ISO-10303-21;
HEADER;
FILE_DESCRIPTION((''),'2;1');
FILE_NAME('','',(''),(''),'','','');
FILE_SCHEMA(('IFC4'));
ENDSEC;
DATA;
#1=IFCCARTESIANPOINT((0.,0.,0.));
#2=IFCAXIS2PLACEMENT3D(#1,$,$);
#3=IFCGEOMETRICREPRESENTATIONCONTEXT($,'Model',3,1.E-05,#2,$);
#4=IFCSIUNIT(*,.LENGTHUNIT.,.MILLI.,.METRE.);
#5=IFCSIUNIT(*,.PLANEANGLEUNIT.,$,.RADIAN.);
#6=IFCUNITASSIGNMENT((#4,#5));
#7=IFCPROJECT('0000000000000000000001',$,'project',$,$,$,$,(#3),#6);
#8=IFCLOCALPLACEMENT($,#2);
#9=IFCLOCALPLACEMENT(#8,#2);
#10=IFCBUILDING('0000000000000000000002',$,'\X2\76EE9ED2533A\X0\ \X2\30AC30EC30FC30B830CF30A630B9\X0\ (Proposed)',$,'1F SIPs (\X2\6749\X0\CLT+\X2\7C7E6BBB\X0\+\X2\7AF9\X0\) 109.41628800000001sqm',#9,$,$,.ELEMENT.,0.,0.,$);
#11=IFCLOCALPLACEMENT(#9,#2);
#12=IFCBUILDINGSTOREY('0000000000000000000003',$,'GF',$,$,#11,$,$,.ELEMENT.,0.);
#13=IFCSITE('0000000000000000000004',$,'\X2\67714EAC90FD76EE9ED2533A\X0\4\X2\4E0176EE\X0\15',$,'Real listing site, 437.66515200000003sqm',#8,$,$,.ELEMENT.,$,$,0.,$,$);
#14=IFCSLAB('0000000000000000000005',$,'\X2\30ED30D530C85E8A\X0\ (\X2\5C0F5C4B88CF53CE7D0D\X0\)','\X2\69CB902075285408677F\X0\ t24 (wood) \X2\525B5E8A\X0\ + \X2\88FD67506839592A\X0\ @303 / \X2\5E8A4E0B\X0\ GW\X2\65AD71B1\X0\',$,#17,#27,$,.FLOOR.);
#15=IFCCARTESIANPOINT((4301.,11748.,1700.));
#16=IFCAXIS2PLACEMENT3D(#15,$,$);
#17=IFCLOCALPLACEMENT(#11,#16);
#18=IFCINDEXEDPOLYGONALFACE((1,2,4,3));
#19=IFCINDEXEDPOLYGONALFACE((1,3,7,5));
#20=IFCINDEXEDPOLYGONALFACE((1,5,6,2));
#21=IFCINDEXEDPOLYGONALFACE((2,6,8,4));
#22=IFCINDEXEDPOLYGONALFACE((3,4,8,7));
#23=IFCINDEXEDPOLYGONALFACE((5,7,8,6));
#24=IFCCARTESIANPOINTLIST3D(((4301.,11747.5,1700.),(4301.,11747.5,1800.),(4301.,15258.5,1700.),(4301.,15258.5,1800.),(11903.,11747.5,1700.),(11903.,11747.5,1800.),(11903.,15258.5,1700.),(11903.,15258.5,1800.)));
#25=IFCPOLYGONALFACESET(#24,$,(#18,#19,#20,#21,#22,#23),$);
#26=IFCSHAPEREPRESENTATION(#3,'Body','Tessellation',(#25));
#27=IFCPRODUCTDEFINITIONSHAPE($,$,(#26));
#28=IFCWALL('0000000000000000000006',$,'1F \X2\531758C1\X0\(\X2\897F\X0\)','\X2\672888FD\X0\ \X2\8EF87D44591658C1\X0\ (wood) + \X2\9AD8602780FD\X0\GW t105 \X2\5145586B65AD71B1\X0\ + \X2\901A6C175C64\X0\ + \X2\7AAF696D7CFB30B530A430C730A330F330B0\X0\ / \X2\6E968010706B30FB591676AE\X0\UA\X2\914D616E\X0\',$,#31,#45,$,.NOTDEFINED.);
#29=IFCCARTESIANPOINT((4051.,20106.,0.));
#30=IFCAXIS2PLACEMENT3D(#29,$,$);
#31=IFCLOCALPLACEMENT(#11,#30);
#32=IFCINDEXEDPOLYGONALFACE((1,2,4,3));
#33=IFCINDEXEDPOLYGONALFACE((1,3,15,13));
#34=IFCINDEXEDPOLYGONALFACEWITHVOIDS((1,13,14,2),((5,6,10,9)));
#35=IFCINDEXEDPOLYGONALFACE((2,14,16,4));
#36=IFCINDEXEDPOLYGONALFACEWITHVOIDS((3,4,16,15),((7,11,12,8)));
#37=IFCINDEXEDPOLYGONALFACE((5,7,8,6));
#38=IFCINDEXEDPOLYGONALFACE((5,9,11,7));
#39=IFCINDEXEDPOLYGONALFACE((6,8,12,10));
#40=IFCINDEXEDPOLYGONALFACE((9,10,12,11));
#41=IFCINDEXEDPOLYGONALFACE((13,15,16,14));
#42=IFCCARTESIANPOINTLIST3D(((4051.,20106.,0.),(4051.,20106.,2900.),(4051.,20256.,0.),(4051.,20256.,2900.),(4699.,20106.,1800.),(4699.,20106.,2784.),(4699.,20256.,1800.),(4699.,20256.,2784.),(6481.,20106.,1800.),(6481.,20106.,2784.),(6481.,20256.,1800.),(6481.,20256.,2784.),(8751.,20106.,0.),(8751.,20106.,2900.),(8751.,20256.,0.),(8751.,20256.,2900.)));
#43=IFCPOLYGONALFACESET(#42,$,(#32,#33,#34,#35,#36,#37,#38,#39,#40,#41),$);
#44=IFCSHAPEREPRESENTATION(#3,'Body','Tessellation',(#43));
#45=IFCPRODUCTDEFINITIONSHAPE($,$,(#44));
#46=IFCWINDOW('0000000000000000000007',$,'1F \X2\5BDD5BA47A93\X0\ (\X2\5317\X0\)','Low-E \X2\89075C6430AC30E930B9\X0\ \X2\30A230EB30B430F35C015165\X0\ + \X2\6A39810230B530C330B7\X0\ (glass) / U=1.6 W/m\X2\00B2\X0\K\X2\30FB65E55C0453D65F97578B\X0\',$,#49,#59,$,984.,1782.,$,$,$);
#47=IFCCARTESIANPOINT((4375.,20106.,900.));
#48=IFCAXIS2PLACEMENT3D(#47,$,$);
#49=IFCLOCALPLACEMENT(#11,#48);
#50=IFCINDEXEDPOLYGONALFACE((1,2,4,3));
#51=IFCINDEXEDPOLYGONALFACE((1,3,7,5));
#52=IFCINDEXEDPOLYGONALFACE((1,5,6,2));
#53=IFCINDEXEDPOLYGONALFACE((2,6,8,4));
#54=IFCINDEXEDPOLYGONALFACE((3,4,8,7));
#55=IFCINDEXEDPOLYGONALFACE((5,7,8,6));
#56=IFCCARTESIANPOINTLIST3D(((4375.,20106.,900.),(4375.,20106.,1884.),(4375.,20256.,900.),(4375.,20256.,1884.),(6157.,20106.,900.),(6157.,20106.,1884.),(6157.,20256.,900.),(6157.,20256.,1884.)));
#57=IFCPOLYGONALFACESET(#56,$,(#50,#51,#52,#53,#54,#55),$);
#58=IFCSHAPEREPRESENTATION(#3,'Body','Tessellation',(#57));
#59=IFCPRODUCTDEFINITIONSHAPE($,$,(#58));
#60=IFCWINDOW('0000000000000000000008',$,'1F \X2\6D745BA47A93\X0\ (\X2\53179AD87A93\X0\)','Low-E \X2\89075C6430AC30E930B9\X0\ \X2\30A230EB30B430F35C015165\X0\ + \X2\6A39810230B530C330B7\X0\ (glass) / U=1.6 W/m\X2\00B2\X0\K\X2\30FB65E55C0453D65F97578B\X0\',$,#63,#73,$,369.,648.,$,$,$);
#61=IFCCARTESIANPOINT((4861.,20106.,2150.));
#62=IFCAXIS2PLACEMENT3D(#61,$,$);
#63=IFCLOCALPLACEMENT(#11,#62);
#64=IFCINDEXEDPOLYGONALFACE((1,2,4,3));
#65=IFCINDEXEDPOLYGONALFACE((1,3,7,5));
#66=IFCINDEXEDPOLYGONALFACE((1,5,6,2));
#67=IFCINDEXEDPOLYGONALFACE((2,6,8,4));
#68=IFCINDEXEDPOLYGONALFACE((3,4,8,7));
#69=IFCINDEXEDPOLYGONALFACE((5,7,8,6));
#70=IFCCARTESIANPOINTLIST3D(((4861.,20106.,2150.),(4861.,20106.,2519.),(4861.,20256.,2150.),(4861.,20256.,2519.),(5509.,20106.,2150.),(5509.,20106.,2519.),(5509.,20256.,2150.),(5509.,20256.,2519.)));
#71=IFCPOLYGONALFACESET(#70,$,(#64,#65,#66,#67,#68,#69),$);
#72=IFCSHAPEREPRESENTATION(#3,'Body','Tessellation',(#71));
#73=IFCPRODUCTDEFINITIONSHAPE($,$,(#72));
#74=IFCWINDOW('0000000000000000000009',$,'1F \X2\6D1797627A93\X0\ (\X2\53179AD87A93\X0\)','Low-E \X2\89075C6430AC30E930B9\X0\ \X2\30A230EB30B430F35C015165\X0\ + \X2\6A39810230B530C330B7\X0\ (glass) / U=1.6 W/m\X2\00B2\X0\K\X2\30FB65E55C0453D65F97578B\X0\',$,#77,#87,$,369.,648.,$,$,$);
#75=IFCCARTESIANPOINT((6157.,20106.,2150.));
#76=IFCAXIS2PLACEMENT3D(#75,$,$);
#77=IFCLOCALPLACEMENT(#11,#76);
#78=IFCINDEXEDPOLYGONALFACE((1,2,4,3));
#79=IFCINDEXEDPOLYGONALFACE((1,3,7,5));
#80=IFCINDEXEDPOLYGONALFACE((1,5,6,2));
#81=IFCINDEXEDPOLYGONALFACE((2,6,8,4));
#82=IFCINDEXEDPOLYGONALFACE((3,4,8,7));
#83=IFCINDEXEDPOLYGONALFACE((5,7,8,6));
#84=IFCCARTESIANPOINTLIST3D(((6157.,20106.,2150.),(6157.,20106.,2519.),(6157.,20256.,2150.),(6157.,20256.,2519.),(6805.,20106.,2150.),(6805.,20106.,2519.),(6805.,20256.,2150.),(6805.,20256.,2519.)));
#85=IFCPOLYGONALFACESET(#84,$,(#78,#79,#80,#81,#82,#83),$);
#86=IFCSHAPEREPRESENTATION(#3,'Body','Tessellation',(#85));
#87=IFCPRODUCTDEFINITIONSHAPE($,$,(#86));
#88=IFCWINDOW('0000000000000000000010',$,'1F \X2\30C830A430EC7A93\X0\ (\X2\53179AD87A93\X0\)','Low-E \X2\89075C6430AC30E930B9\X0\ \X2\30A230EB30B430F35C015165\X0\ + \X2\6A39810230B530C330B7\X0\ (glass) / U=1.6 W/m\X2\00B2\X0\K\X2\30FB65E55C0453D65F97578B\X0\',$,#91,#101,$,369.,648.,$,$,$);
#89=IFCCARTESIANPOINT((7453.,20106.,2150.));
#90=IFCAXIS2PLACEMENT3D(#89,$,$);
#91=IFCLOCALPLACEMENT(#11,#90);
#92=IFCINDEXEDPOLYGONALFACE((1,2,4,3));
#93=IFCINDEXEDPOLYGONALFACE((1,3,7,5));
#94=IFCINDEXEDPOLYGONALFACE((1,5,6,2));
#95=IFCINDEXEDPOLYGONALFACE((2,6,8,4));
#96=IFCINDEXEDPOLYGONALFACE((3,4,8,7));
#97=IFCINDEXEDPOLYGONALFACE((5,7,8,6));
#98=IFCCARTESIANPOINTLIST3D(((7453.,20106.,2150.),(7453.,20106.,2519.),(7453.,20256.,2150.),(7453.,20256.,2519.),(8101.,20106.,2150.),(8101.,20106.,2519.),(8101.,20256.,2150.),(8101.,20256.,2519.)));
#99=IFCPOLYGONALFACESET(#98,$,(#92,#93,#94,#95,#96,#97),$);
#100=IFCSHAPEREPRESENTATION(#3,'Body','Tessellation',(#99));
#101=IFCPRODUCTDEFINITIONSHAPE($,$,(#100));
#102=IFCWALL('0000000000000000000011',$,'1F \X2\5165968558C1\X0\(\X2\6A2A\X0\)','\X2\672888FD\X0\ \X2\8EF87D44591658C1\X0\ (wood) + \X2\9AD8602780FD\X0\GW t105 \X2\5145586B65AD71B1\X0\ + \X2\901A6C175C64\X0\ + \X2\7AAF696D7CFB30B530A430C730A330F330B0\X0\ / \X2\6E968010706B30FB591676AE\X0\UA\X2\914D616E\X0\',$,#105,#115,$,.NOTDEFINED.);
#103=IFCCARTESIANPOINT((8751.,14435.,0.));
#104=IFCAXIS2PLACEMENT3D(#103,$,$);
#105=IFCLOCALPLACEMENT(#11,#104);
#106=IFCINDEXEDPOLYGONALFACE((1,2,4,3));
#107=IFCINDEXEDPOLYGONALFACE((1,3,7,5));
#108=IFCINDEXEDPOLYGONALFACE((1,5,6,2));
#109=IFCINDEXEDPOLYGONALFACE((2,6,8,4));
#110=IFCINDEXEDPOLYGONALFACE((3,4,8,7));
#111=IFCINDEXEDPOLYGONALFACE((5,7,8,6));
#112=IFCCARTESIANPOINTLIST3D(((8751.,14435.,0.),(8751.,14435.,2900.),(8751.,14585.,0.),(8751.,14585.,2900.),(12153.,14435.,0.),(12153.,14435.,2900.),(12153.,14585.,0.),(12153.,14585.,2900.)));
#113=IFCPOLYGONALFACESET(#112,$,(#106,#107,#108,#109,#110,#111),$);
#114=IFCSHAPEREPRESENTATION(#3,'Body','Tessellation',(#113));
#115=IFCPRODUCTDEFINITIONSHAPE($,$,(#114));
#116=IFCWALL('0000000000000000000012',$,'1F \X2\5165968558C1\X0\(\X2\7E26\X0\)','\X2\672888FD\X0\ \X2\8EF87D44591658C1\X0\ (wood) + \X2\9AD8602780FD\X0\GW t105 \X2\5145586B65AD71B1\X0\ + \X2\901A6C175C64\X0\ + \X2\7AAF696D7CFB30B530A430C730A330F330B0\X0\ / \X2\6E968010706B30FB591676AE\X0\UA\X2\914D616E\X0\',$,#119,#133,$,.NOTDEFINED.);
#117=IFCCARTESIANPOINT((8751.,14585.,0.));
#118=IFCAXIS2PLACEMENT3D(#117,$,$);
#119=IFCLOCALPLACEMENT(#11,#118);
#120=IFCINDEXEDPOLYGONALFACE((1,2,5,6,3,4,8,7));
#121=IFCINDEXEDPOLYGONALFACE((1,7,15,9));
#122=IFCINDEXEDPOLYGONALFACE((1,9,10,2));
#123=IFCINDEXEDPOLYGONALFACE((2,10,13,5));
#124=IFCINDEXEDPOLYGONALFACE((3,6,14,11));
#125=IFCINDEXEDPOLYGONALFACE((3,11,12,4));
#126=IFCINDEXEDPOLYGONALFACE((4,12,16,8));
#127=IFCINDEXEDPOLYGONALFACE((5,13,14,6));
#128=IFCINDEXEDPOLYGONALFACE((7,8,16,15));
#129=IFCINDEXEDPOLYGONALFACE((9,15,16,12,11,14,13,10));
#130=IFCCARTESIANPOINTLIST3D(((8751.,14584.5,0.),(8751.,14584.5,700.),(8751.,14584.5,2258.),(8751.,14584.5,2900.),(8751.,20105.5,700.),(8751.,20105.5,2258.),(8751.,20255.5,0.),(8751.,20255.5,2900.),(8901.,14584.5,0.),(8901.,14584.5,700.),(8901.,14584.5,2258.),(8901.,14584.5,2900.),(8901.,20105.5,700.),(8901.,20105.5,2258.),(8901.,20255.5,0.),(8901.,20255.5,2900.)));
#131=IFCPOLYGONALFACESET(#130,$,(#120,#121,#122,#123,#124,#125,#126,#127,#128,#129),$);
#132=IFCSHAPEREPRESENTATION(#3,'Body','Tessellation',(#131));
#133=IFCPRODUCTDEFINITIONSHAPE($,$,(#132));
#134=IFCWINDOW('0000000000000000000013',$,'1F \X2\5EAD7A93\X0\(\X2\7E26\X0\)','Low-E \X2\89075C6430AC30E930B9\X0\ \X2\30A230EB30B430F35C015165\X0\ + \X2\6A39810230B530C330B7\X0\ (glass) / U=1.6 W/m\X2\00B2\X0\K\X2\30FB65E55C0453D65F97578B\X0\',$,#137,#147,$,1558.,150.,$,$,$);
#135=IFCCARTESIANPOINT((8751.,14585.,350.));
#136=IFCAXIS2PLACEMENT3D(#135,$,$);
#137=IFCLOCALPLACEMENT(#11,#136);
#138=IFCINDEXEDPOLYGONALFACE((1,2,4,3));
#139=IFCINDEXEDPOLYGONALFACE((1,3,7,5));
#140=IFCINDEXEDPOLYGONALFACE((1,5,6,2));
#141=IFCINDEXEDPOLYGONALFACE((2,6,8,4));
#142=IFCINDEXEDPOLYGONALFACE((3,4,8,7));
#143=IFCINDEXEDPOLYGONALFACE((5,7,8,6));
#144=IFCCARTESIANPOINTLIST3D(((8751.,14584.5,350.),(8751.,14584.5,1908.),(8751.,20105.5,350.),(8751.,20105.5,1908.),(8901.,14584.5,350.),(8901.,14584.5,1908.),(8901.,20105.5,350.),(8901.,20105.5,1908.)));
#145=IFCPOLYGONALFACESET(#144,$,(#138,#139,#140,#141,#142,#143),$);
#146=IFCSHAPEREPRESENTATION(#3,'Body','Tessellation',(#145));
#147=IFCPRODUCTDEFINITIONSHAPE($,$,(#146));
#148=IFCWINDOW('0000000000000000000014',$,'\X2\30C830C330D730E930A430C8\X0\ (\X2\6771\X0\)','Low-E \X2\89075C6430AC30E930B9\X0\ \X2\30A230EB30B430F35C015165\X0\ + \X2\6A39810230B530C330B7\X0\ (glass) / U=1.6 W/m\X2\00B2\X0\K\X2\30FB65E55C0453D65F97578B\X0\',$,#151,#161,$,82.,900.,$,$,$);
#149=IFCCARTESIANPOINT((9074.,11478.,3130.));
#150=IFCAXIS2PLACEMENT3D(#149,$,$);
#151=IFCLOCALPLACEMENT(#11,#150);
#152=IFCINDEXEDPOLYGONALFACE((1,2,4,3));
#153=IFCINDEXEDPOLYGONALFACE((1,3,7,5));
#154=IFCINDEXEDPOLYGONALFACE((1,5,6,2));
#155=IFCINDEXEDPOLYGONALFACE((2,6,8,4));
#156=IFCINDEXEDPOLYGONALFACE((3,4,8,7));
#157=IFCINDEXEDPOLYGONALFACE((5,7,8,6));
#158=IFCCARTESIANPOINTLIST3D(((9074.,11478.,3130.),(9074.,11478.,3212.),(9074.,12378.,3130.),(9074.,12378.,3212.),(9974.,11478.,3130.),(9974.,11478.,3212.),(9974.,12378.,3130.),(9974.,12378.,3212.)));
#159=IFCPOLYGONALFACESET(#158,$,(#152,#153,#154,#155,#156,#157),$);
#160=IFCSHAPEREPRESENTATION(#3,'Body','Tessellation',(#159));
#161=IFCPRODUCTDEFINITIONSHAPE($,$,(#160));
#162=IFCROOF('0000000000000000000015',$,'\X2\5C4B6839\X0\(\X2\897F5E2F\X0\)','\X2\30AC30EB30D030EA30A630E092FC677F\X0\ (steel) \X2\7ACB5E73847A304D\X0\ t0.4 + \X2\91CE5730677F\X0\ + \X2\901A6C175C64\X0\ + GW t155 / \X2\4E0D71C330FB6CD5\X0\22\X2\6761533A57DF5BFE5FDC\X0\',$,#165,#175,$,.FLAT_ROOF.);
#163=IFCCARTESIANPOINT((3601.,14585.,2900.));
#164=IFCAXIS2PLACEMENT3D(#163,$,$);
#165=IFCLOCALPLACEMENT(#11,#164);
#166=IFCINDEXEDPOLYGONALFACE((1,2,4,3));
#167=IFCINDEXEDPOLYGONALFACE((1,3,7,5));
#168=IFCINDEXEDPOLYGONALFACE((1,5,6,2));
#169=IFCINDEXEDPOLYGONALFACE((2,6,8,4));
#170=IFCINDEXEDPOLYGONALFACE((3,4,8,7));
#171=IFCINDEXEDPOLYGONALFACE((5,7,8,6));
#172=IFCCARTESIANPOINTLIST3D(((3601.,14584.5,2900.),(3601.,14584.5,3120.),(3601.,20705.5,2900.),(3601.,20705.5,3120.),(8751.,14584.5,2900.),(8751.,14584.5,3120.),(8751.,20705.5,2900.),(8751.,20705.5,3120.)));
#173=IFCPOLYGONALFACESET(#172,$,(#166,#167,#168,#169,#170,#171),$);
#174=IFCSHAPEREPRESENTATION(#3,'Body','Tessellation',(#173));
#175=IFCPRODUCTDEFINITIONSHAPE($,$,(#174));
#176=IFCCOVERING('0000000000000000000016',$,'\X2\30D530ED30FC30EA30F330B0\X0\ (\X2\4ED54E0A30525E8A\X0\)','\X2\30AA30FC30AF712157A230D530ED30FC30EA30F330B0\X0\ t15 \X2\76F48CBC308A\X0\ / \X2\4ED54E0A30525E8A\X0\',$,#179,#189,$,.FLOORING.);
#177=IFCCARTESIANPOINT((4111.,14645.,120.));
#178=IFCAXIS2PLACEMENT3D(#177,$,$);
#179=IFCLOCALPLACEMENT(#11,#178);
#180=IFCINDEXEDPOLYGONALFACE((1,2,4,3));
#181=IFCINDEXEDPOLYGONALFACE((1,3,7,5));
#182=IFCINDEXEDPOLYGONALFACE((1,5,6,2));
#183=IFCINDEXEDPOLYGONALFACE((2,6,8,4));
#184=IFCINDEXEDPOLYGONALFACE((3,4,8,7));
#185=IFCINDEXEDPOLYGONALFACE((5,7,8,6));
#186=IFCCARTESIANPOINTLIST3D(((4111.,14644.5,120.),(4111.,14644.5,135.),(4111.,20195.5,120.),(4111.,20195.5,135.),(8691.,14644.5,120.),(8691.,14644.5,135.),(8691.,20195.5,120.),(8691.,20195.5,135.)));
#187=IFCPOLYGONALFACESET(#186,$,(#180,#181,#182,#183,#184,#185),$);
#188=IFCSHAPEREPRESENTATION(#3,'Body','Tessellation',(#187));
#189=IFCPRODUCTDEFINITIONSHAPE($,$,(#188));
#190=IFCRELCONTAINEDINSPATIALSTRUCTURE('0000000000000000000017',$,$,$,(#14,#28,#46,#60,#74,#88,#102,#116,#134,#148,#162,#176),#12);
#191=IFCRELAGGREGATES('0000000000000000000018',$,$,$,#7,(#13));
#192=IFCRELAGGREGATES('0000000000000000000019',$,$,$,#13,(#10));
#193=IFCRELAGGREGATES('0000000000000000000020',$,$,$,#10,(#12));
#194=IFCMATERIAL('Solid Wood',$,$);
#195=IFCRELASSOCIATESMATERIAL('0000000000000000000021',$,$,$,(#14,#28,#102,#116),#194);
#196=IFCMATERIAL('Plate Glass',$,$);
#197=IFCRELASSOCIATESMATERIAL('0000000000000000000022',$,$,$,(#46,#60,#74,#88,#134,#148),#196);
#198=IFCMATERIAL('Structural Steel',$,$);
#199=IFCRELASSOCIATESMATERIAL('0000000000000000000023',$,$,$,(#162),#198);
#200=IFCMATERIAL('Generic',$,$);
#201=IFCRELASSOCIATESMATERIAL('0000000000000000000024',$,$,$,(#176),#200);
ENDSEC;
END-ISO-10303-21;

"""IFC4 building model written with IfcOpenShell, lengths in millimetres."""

from ifc_helpers import new_model, si_unit, frame, frame_2d, origin, place, context, project, spatial, rectangle, extrude, material, element, fill, save


model = new_model("IFC4")

# Units and contexts
model_context = context("Model", 3, precision=1e-05, world=origin())
ifc_project = project(units=[si_unit("LENGTHUNIT", "METRE", prefix="MILLI"), si_unit("PLANEANGLEUNIT", "RADIAN")], contexts=[model_context])

# Site, building, storey
site_placement = place(None, origin())
site = spatial("IfcSite", under=ifc_project, at=site_placement, Name="東京都目黒区4丁目15", ObjectType="Real listing site, 437.66515200000003sqm", CompositionType="ELEMENT", RefElevation=0.0)
building_placement = place(site_placement, origin())
building = spatial("IfcBuilding", under=site, at=building_placement, Name="目黒区 ガレージハウス (Proposed)", ObjectType="1F SIPs (杉CLT+籾殻+竹) 109.41628800000001sqm", CompositionType="ELEMENT", ElevationOfRefHeight=0.0, ElevationOfTerrain=0.0)
storey_placement = place(building_placement, origin())
storey = spatial("IfcBuildingStorey", under=building, at=storey_placement, Name="GF", CompositionType="ELEMENT", Elevation=0.0)

# Slab
ifc_material_1 = material(Name="Solid Wood")
slab_1_placement = place(storey_placement, frame((4301.0, 11748.0, 1700.0)))
element("IfcSlab", 1, at=slab_1_placement, inside=storey, material=ifc_material_1, Name="ロフト床 (小屋裏収納)", Description="構造用合板 t24 (wood) 剛床 + 製材根太 @303 / 床下 GW断熱", PredefinedType="FLOOR", context=model_context, shape_type="SweptSolid", body=[
    extrude(rectangle(XDim=7602.0, YDim=3511.0, at=frame_2d((3801.0, 1755.0))), frame((4301.0, 11748.0, 1700.0)), (0.0, 0.0, 1.0), 100.0),
])

# Wall, openings, windows
wall_1_placement = place(storey_placement, frame((4051.0, 20106.0, 0.0)))
wall_1 = element("IfcWall", 2, at=wall_1_placement, inside=storey, material=ifc_material_1, Name="1F 北壁(西)", Description="木製 軸組外壁 (wood) + 高性能GW t105 充填断熱 + 通気層 + 窯業系サイディング / 準耐火・外皮UA配慮", PredefinedType="NOTDEFINED", context=model_context, shape_type="SweptSolid", body=[
    extrude(rectangle(XDim=4700.0, YDim=150.0, at=frame_2d((2350.0, 75.0))), frame((4051.0, 20106.0, 0.0)), (0.0, 0.0, 1.0), 2900.0),
])
opening_1_placement = place(storey_placement, frame((4375.0, 20106.0, 900.0)))
opening_1 = element("IfcOpeningElement", 3, at=opening_1_placement, cuts=wall_1, PredefinedType="NOTDEFINED", context=model_context, shape_type="SweptSolid", body=[
    extrude(rectangle(XDim=1782.0, YDim=150.0, at=frame_2d((891.0, 75.0))), frame((4375.0, 20106.0, 900.0)), (0.0, 0.0, 1.0), 984.0),
])
opening_2_placement = place(storey_placement, frame((4861.0, 20106.0, 2150.0)))
opening_2 = element("IfcOpeningElement", 4, at=opening_2_placement, cuts=wall_1, PredefinedType="NOTDEFINED", context=model_context, shape_type="SweptSolid", body=[
    extrude(rectangle(XDim=648.0, YDim=150.0, at=frame_2d((324.0, 75.0))), frame((4861.0, 20106.0, 2150.0)), (0.0, 0.0, 1.0), 369.0),
])
opening_3_placement = place(storey_placement, frame((6157.0, 20106.0, 2150.0)))
opening_3 = element("IfcOpeningElement", 5, at=opening_3_placement, cuts=wall_1, PredefinedType="NOTDEFINED", context=model_context, shape_type="SweptSolid", body=[
    extrude(rectangle(XDim=648.0, YDim=150.0, at=frame_2d((324.0, 75.0))), frame((6157.0, 20106.0, 2150.0)), (0.0, 0.0, 1.0), 369.0),
])
opening_4_placement = place(storey_placement, frame((7453.0, 20106.0, 2150.0)))
opening_4 = element("IfcOpeningElement", 6, at=opening_4_placement, cuts=wall_1, PredefinedType="NOTDEFINED", context=model_context, shape_type="SweptSolid", body=[
    extrude(rectangle(XDim=648.0, YDim=150.0, at=frame_2d((324.0, 75.0))), frame((7453.0, 20106.0, 2150.0)), (0.0, 0.0, 1.0), 369.0),
])
ifc_material_2 = material(Name="Plate Glass")
window_1_placement = place(storey_placement, frame((4375.0, 20106.0, 900.0)))
window_1 = element("IfcWindow", 7, at=window_1_placement, inside=storey, material=ifc_material_2, Name="1F 寝室窓 (北)", Description="Low-E 複層ガラス アルゴン封入 + 樹脂サッシ (glass) / U=1.6 W/m²K・日射取得型", OverallHeight=984.0, OverallWidth=1782.0, context=model_context, shape_type="SweptSolid", body=[
    extrude(rectangle(XDim=1782.0, YDim=150.0, at=frame_2d((891.0, 75.0))), frame((4375.0, 20106.0, 900.0)), (0.0, 0.0, 1.0), 984.0),
])
fill(opening_1, window_1)
window_2_placement = place(storey_placement, frame((4861.0, 20106.0, 2150.0)))
window_2 = element("IfcWindow", 8, at=window_2_placement, inside=storey, material=ifc_material_2, Name="1F 浴室窓 (北高窓)", Description="Low-E 複層ガラス アルゴン封入 + 樹脂サッシ (glass) / U=1.6 W/m²K・日射取得型", OverallHeight=369.0, OverallWidth=648.0, context=model_context, shape_type="SweptSolid", body=[
    extrude(rectangle(XDim=648.0, YDim=150.0, at=frame_2d((324.0, 75.0))), frame((4861.0, 20106.0, 2150.0)), (0.0, 0.0, 1.0), 369.0),
])
fill(opening_2, window_2)
window_3_placement = place(storey_placement, frame((6157.0, 20106.0, 2150.0)))
window_3 = element("IfcWindow", 9, at=window_3_placement, inside=storey, material=ifc_material_2, Name="1F 洗面窓 (北高窓)", Description="Low-E 複層ガラス アルゴン封入 + 樹脂サッシ (glass) / U=1.6 W/m²K・日射取得型", OverallHeight=369.0, OverallWidth=648.0, context=model_context, shape_type="SweptSolid", body=[
    extrude(rectangle(XDim=648.0, YDim=150.0, at=frame_2d((324.0, 75.0))), frame((6157.0, 20106.0, 2150.0)), (0.0, 0.0, 1.0), 369.0),
])
fill(opening_3, window_3)
window_4_placement = place(storey_placement, frame((7453.0, 20106.0, 2150.0)))
window_4 = element("IfcWindow", 10, at=window_4_placement, inside=storey, material=ifc_material_2, Name="1F トイレ窓 (北高窓)", Description="Low-E 複層ガラス アルゴン封入 + 樹脂サッシ (glass) / U=1.6 W/m²K・日射取得型", OverallHeight=369.0, OverallWidth=648.0, context=model_context, shape_type="SweptSolid", body=[
    extrude(rectangle(XDim=648.0, YDim=150.0, at=frame_2d((324.0, 75.0))), frame((7453.0, 20106.0, 2150.0)), (0.0, 0.0, 1.0), 369.0),
])
fill(opening_4, window_4)

# Wall
wall_2_placement = place(storey_placement, frame((8751.0, 14435.0, 0.0)))
element("IfcWall", 11, at=wall_2_placement, inside=storey, material=ifc_material_1, Name="1F 入隅壁(横)", Description="木製 軸組外壁 (wood) + 高性能GW t105 充填断熱 + 通気層 + 窯業系サイディング / 準耐火・外皮UA配慮", PredefinedType="NOTDEFINED", context=model_context, shape_type="SweptSolid", body=[
    extrude(rectangle(XDim=3402.0, YDim=150.0, at=frame_2d((1701.0, 75.0))), frame((8751.0, 14435.0, 0.0)), (0.0, 0.0, 1.0), 2900.0),
])

# Wall, opening, window
wall_3_placement = place(storey_placement, frame((8751.0, 14585.0, 0.0)))
wall_3 = element("IfcWall", 12, at=wall_3_placement, inside=storey, material=ifc_material_1, Name="1F 入隅壁(縦)", Description="木製 軸組外壁 (wood) + 高性能GW t105 充填断熱 + 通気層 + 窯業系サイディング / 準耐火・外皮UA配慮", PredefinedType="NOTDEFINED", context=model_context, shape_type="SweptSolid", body=[
    extrude(rectangle(XDim=150.0, YDim=5671.0, at=frame_2d((75.0, 2835.0))), frame((8751.0, 14585.0, 0.0)), (0.0, 0.0, 1.0), 2900.0),
])
opening_5_placement = place(storey_placement, frame((8751.0, 14585.0, 350.0)))
opening_5 = element("IfcOpeningElement", 13, at=opening_5_placement, cuts=wall_3, PredefinedType="NOTDEFINED", context=model_context, shape_type="SweptSolid", body=[
    extrude(rectangle(XDim=150.0, YDim=5521.0, at=frame_2d((75.0, 2760.0))), frame((8751.0, 14585.0, 350.0)), (0.0, 0.0, 1.0), 1558.0),
])
window_5_placement = place(storey_placement, frame((8751.0, 14585.0, 350.0)))
window_5 = element("IfcWindow", 14, at=window_5_placement, inside=storey, material=ifc_material_2, Name="1F 庭窓(縦)", Description="Low-E 複層ガラス アルゴン封入 + 樹脂サッシ (glass) / U=1.6 W/m²K・日射取得型", OverallHeight=1558.0, OverallWidth=150.0, context=model_context, shape_type="SweptSolid", body=[
    extrude(rectangle(XDim=150.0, YDim=5521.0, at=frame_2d((75.0, 2760.0))), frame((8751.0, 14585.0, 350.0)), (0.0, 0.0, 1.0), 1558.0),
])
fill(opening_5, window_5)

# Window
window_6_placement = place(storey_placement, frame((9074.0, 11478.0, 3130.0)))
element("IfcWindow", 15, at=window_6_placement, inside=storey, material=ifc_material_2, Name="トップライト (東)", Description="Low-E 複層ガラス アルゴン封入 + 樹脂サッシ (glass) / U=1.6 W/m²K・日射取得型", OverallHeight=82.0, OverallWidth=900.0, context=model_context, shape_type="SweptSolid", body=[
    extrude(rectangle(XDim=900.0, YDim=900.0, at=frame_2d((450.0, 450.0))), frame((9074.0, 11478.0, 3130.0)), (0.0, 0.0, 1.0), 82.0),
])

# Roof
ifc_material_3 = material(Name="Structural Steel")
roof_placement = place(storey_placement, frame((3601.0, 14585.0, 2900.0)))
element("IfcRoof", 16, at=roof_placement, inside=storey, material=ifc_material_3, Name="屋根(西帯)", Description="ガルバリウム鋼板 (steel) 立平葺き t0.4 + 野地板 + 通気層 + GW t155 / 不燃・法22条区域対応", PredefinedType="FLAT_ROOF", context=model_context, shape_type="SweptSolid", body=[
    extrude(rectangle(XDim=5150.0, YDim=6121.0, at=frame_2d((2575.0, 3060.0))), frame((3601.0, 14585.0, 2900.0)), (0.0, 0.0, 1.0), 220.0),
])

# Covering
ifc_material_4 = material(Name="Generic")
covering_placement = place(storey_placement, frame((4111.0, 14645.0, 120.0)))
element("IfcCovering", 17, at=covering_placement, inside=storey, material=ifc_material_4, Name="フローリング (仕上げ床)", Description="オーク無垢フローリング t15 直貼り / 仕上げ床", PredefinedType="FLOORING", context=model_context, shape_type="SweptSolid", body=[
    extrude(rectangle(XDim=4580.0, YDim=5551.0, at=frame_2d((2290.0, 2775.0))), frame((4111.0, 14645.0, 120.0)), (0.0, 0.0, 1.0), 15.0),
])

save(model, "model.ifc")
